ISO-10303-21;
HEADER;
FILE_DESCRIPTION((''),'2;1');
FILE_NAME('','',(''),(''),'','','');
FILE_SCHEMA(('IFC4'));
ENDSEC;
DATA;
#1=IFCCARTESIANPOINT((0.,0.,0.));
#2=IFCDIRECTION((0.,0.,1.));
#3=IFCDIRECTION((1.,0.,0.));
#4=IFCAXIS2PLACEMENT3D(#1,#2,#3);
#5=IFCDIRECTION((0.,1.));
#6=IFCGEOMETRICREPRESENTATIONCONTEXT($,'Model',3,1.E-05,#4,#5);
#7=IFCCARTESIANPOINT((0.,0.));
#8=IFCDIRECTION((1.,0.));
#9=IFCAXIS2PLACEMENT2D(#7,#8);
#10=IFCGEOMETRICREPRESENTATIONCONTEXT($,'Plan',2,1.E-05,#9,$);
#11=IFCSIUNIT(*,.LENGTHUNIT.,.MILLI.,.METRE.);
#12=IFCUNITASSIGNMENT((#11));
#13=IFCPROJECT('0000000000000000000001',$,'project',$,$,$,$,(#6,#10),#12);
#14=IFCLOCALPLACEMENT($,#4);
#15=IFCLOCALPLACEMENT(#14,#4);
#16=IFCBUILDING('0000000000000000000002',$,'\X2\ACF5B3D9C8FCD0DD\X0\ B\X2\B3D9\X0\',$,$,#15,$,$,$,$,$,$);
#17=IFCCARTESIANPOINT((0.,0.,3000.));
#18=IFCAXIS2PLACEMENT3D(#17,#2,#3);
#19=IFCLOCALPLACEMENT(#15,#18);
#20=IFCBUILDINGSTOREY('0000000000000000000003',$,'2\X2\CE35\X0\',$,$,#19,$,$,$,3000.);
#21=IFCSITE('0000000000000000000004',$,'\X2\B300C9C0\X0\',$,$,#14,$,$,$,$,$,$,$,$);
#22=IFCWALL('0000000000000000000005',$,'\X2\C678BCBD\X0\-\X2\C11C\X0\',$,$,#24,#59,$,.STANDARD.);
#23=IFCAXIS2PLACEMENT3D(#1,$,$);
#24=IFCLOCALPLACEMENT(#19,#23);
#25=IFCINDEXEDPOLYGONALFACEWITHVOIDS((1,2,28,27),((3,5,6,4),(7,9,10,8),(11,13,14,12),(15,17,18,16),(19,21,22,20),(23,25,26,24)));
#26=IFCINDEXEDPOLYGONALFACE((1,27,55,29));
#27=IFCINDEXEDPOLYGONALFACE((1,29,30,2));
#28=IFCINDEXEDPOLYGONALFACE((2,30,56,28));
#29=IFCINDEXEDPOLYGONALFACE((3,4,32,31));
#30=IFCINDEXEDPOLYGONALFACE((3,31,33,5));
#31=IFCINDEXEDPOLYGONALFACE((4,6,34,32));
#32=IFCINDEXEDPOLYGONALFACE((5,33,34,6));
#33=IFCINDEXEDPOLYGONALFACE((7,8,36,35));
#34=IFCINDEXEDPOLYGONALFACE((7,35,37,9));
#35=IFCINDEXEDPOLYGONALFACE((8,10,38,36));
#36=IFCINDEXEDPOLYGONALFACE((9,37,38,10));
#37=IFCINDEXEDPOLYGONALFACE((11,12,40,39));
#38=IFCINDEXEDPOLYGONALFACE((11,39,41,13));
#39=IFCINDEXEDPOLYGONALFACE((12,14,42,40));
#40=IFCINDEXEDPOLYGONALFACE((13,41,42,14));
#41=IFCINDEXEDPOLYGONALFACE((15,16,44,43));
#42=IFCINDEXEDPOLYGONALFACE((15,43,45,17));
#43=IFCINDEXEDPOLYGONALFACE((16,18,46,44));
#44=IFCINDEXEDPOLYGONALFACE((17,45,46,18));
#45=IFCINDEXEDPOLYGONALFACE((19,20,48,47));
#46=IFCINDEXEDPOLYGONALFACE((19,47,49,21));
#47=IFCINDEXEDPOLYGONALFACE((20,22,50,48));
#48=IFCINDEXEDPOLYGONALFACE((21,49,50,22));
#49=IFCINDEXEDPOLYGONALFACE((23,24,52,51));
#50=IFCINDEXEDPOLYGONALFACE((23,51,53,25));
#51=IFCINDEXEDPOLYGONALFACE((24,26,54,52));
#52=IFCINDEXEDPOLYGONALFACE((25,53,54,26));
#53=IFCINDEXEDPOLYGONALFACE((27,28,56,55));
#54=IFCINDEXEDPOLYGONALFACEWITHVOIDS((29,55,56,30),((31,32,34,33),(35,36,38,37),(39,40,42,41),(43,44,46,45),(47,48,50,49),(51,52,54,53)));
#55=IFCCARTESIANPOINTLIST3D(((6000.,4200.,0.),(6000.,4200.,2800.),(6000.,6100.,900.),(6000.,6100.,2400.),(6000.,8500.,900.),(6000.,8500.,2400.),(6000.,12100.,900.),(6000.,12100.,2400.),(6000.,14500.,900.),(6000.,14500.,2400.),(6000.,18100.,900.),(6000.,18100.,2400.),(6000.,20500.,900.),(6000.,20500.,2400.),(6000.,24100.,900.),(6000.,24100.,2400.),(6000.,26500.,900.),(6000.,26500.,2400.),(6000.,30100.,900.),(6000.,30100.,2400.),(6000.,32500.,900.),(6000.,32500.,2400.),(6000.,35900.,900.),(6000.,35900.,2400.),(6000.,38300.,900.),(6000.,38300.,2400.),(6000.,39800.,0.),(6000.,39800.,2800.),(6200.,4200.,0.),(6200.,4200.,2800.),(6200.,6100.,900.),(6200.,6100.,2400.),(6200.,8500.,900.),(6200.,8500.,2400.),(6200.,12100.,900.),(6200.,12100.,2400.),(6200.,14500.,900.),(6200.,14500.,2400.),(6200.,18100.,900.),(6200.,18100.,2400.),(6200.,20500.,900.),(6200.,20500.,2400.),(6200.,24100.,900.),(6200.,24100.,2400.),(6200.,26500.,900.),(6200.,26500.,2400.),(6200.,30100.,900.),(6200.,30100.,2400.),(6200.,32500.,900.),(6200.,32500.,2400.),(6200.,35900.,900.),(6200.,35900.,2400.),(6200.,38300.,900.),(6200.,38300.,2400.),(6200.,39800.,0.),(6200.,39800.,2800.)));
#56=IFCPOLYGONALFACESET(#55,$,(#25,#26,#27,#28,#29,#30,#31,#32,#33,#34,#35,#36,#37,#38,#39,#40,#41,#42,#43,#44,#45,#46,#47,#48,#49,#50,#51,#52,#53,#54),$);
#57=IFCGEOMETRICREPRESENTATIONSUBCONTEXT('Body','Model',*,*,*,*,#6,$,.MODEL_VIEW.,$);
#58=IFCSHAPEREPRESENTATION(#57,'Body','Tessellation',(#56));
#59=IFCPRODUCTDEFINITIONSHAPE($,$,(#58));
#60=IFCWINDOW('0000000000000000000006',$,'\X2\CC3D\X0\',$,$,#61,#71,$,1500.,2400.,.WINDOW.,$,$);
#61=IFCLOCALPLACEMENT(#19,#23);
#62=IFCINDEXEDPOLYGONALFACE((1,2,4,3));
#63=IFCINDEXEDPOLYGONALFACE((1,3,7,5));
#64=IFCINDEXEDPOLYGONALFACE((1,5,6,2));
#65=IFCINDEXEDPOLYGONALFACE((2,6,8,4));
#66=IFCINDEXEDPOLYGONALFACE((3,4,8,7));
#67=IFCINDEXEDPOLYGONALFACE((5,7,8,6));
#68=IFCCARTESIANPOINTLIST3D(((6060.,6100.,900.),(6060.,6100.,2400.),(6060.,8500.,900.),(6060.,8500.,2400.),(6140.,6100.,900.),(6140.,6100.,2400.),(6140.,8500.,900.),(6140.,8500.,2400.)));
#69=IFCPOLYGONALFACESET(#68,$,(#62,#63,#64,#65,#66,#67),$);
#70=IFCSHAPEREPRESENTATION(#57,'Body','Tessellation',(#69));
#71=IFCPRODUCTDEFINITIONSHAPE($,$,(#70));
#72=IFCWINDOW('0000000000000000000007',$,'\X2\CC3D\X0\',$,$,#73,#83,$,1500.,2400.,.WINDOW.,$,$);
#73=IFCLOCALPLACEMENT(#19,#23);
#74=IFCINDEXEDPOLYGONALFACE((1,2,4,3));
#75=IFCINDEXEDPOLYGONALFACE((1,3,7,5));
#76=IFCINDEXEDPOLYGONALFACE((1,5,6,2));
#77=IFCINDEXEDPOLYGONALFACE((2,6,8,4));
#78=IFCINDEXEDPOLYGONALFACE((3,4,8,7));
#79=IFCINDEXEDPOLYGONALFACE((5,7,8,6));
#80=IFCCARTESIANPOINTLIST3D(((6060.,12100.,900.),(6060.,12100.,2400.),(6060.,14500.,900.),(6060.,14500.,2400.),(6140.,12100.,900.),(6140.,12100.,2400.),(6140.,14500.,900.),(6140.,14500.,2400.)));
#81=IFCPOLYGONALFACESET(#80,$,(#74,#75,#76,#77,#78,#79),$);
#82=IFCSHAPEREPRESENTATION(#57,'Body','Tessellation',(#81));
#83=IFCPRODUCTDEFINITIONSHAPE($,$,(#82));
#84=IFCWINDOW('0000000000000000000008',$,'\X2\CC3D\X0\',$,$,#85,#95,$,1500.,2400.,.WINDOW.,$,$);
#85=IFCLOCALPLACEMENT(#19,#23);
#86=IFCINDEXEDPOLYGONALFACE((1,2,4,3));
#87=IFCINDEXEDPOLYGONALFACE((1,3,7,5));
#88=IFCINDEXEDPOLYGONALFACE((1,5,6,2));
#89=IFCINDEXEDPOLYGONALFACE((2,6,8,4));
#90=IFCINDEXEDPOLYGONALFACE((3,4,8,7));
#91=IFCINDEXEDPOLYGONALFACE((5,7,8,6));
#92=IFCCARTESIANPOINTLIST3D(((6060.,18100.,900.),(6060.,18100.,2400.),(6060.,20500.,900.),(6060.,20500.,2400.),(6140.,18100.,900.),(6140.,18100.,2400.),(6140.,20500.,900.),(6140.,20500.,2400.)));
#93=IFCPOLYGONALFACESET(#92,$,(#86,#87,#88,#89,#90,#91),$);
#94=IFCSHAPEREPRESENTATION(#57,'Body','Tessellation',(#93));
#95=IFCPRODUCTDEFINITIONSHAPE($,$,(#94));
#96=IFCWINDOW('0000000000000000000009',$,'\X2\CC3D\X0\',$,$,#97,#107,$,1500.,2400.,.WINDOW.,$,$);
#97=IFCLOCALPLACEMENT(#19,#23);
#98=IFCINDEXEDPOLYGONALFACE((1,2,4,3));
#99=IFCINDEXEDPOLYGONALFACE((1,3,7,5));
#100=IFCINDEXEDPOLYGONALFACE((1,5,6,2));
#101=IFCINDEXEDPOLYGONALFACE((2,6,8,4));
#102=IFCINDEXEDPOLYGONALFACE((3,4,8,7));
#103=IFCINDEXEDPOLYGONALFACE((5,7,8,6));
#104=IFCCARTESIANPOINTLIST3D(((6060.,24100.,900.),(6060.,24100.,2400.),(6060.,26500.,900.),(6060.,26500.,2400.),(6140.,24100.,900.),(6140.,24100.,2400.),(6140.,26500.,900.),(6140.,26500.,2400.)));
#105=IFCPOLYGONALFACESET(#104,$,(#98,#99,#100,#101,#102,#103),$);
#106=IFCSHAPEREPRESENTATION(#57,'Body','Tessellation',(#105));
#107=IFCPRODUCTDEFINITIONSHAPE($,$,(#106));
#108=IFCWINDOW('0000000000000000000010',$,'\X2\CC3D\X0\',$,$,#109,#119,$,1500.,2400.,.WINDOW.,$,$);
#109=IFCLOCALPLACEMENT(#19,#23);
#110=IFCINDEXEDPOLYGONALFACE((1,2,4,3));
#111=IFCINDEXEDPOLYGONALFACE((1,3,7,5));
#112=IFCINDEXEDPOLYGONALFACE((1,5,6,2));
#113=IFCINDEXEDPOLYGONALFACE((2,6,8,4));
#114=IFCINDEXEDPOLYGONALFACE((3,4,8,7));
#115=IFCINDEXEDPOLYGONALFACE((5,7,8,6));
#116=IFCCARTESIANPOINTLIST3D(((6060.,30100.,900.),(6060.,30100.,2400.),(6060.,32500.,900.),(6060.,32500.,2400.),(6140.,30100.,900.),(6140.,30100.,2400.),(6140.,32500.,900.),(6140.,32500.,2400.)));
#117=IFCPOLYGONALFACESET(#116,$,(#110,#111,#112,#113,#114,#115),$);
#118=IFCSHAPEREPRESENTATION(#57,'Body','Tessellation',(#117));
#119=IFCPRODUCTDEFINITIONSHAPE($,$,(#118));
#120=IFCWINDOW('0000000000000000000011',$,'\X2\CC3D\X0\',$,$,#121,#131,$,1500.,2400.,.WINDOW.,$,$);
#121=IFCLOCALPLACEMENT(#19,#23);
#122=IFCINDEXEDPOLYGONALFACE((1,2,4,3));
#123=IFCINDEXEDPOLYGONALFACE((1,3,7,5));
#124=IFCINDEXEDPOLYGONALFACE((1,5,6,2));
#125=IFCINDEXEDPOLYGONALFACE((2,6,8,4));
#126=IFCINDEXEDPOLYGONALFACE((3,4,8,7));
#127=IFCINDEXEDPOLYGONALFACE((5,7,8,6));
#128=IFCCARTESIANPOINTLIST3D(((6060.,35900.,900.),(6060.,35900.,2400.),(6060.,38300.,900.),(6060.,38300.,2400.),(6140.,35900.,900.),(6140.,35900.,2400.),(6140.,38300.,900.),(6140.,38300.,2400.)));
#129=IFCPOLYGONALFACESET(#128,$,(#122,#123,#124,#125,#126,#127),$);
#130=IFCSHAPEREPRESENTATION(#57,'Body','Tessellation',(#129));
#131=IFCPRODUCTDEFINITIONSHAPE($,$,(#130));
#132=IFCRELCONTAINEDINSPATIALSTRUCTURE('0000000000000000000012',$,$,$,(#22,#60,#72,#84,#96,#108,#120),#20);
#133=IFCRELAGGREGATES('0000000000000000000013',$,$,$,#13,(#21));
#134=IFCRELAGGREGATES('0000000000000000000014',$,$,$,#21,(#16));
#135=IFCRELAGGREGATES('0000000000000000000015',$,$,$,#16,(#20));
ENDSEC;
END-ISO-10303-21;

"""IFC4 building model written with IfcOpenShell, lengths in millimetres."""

from ifc_helpers import new_model, si_unit, direction, frame, origin_with_axes, origin_2d_with_axis, place, context, subcontext, project, spatial, polyline, outline, extrude, element, fill, save


model = new_model("IFC4")

# Units and contexts
model_context = context("Model", 3, precision=1e-05, world=origin_with_axes(), true_north=direction((0.0, 1.0)))
plan_context = context("Plan", 2, precision=1e-05, world=origin_2d_with_axis())
body_context = subcontext(model_context, "Body", "Model", "MODEL_VIEW")
ifc_project = project(units=[si_unit("LENGTHUNIT", "METRE", prefix="MILLI")], contexts=[model_context, plan_context])

# Site, building, storey
site_placement = place(None, origin_with_axes())
site = spatial("IfcSite", under=ifc_project, at=site_placement, Name="대지")
building_placement = place(site_placement, origin_with_axes())
building = spatial("IfcBuilding", under=site, at=building_placement, Name="공동주택 B동")
storey_placement = place(building_placement, frame((0.0, 0.0, 3000.0), z_axis=(0.0, 0.0, 1.0), x_axis=(1.0, 0.0, 0.0)))
storey = spatial("IfcBuildingStorey", under=building, at=storey_placement, Name="2층", Elevation=3000.0)

# Wall, openings, windows
wall_1_placement = place(storey_placement, origin_with_axes())
wall_1 = element("IfcWall", 1, at=wall_1_placement, inside=storey, Name="외벽-서", PredefinedType="STANDARD", context=body_context, shape_type="SweptSolid", body=[
    extrude(outline(polyline([(6200.0, 39800.0), (6200.0, 4200.0), (6000.0, 4200.0), (6000.0, 39800.0), (6200.0, 39800.0)])), origin_with_axes(), (0.0, 0.0, 1.0), 2800.0),
])
opening_1_placement = place(storey_placement, origin_with_axes())
opening_1 = element("IfcOpeningElement", 2, at=opening_1_placement, cuts=wall_1, PredefinedType="OPENING", context=body_context, shape_type="SweptSolid", body=[
    extrude(outline(polyline([(5950.0, 8500.0), (5950.0, 6100.0), (6250.0, 6100.0), (6250.0, 8500.0), (5950.0, 8500.0)])), frame((0.0, 0.0, 900.0), z_axis=(0.0, 0.0, 1.0), x_axis=(1.0, 0.0, 0.0)), (0.0, 0.0, 1.0), 1500.0),
])
opening_2_placement = place(storey_placement, origin_with_axes())
opening_2 = element("IfcOpeningElement", 3, at=opening_2_placement, cuts=wall_1, PredefinedType="OPENING", context=body_context, shape_type="SweptSolid", body=[
    extrude(outline(polyline([(5950.0, 14500.0), (5950.0, 12100.0), (6250.0, 12100.0), (6250.0, 14500.0), (5950.0, 14500.0)])), frame((0.0, 0.0, 900.0), z_axis=(0.0, 0.0, 1.0), x_axis=(1.0, 0.0, 0.0)), (0.0, 0.0, 1.0), 1500.0),
])
opening_3_placement = place(storey_placement, origin_with_axes())
opening_3 = element("IfcOpeningElement", 4, at=opening_3_placement, cuts=wall_1, PredefinedType="OPENING", context=body_context, shape_type="SweptSolid", body=[
    extrude(outline(polyline([(5950.0, 20500.0), (5950.0, 18100.0), (6250.0, 18100.0), (6250.0, 20500.0), (5950.0, 20500.0)])), frame((0.0, 0.0, 900.0), z_axis=(0.0, 0.0, 1.0), x_axis=(1.0, 0.0, 0.0)), (0.0, 0.0, 1.0), 1500.0),
])
opening_4_placement = place(storey_placement, origin_with_axes())
opening_4 = element("IfcOpeningElement", 5, at=opening_4_placement, cuts=wall_1, PredefinedType="OPENING", context=body_context, shape_type="SweptSolid", body=[
    extrude(outline(polyline([(5950.0, 26500.0), (5950.0, 24100.0), (6250.0, 24100.0), (6250.0, 26500.0), (5950.0, 26500.0)])), frame((0.0, 0.0, 900.0), z_axis=(0.0, 0.0, 1.0), x_axis=(1.0, 0.0, 0.0)), (0.0, 0.0, 1.0), 1500.0),
])
opening_5_placement = place(storey_placement, origin_with_axes())
opening_5 = element("IfcOpeningElement", 6, at=opening_5_placement, cuts=wall_1, PredefinedType="OPENING", context=body_context, shape_type="SweptSolid", body=[
    extrude(outline(polyline([(5950.0, 32500.0), (5950.0, 30100.0), (6250.0, 30100.0), (6250.0, 32500.0), (5950.0, 32500.0)])), frame((0.0, 0.0, 900.0), z_axis=(0.0, 0.0, 1.0), x_axis=(1.0, 0.0, 0.0)), (0.0, 0.0, 1.0), 1500.0),
])
opening_6_placement = place(storey_placement, origin_with_axes())
opening_6 = element("IfcOpeningElement", 7, at=opening_6_placement, cuts=wall_1, PredefinedType="OPENING", context=body_context, shape_type="SweptSolid", body=[
    extrude(outline(polyline([(5950.0, 38300.0), (5950.0, 35900.0), (6250.0, 35900.0), (6250.0, 38300.0), (5950.0, 38300.0)])), frame((0.0, 0.0, 900.0), z_axis=(0.0, 0.0, 1.0), x_axis=(1.0, 0.0, 0.0)), (0.0, 0.0, 1.0), 1500.0),
])
window_1_placement = place(storey_placement, origin_with_axes())
window_1 = element("IfcWindow", 8, at=window_1_placement, inside=storey, Name="창", OverallHeight=1500.0, OverallWidth=2400.0, PredefinedType="WINDOW", context=body_context, shape_type="SweptSolid", body=[
    extrude(outline(polyline([(6060.0, 8500.0), (6060.0, 6100.0), (6140.0, 6100.0), (6140.0, 8500.0), (6060.0, 8500.0)])), frame((0.0, 0.0, 900.0), z_axis=(0.0, 0.0, 1.0), x_axis=(1.0, 0.0, 0.0)), (0.0, 0.0, 1.0), 1500.0),
])
fill(opening_1, window_1)
window_2_placement = place(storey_placement, origin_with_axes())
window_2 = element("IfcWindow", 9, at=window_2_placement, inside=storey, Name="창", OverallHeight=1500.0, OverallWidth=2400.0, PredefinedType="WINDOW", context=body_context, shape_type="SweptSolid", body=[
    extrude(outline(polyline([(6060.0, 14500.0), (6060.0, 12100.0), (6140.0, 12100.0), (6140.0, 14500.0), (6060.0, 14500.0)])), frame((0.0, 0.0, 900.0), z_axis=(0.0, 0.0, 1.0), x_axis=(1.0, 0.0, 0.0)), (0.0, 0.0, 1.0), 1500.0),
])
fill(opening_2, window_2)
window_3_placement = place(storey_placement, origin_with_axes())
window_3 = element("IfcWindow", 10, at=window_3_placement, inside=storey, Name="창", OverallHeight=1500.0, OverallWidth=2400.0, PredefinedType="WINDOW", context=body_context, shape_type="SweptSolid", body=[
    extrude(outline(polyline([(6060.0, 20500.0), (6060.0, 18100.0), (6140.0, 18100.0), (6140.0, 20500.0), (6060.0, 20500.0)])), frame((0.0, 0.0, 900.0), z_axis=(0.0, 0.0, 1.0), x_axis=(1.0, 0.0, 0.0)), (0.0, 0.0, 1.0), 1500.0),
])
fill(opening_3, window_3)
window_4_placement = place(storey_placement, origin_with_axes())
window_4 = element("IfcWindow", 11, at=window_4_placement, inside=storey, Name="창", OverallHeight=1500.0, OverallWidth=2400.0, PredefinedType="WINDOW", context=body_context, shape_type="SweptSolid", body=[
    extrude(outline(polyline([(6060.0, 26500.0), (6060.0, 24100.0), (6140.0, 24100.0), (6140.0, 26500.0), (6060.0, 26500.0)])), frame((0.0, 0.0, 900.0), z_axis=(0.0, 0.0, 1.0), x_axis=(1.0, 0.0, 0.0)), (0.0, 0.0, 1.0), 1500.0),
])
fill(opening_4, window_4)
window_5_placement = place(storey_placement, origin_with_axes())
window_5 = element("IfcWindow", 12, at=window_5_placement, inside=storey, Name="창", OverallHeight=1500.0, OverallWidth=2400.0, PredefinedType="WINDOW", context=body_context, shape_type="SweptSolid", body=[
    extrude(outline(polyline([(6060.0, 32500.0), (6060.0, 30100.0), (6140.0, 30100.0), (6140.0, 32500.0), (6060.0, 32500.0)])), frame((0.0, 0.0, 900.0), z_axis=(0.0, 0.0, 1.0), x_axis=(1.0, 0.0, 0.0)), (0.0, 0.0, 1.0), 1500.0),
])
fill(opening_5, window_5)
window_6_placement = place(storey_placement, origin_with_axes())
window_6 = element("IfcWindow", 13, at=window_6_placement, inside=storey, Name="창", OverallHeight=1500.0, OverallWidth=2400.0, PredefinedType="WINDOW", context=body_context, shape_type="SweptSolid", body=[
    extrude(outline(polyline([(6060.0, 38300.0), (6060.0, 35900.0), (6140.0, 35900.0), (6140.0, 38300.0), (6060.0, 38300.0)])), frame((0.0, 0.0, 900.0), z_axis=(0.0, 0.0, 1.0), x_axis=(1.0, 0.0, 0.0)), (0.0, 0.0, 1.0), 1500.0),
])
fill(opening_6, window_6)

save(model, "model.ifc")
